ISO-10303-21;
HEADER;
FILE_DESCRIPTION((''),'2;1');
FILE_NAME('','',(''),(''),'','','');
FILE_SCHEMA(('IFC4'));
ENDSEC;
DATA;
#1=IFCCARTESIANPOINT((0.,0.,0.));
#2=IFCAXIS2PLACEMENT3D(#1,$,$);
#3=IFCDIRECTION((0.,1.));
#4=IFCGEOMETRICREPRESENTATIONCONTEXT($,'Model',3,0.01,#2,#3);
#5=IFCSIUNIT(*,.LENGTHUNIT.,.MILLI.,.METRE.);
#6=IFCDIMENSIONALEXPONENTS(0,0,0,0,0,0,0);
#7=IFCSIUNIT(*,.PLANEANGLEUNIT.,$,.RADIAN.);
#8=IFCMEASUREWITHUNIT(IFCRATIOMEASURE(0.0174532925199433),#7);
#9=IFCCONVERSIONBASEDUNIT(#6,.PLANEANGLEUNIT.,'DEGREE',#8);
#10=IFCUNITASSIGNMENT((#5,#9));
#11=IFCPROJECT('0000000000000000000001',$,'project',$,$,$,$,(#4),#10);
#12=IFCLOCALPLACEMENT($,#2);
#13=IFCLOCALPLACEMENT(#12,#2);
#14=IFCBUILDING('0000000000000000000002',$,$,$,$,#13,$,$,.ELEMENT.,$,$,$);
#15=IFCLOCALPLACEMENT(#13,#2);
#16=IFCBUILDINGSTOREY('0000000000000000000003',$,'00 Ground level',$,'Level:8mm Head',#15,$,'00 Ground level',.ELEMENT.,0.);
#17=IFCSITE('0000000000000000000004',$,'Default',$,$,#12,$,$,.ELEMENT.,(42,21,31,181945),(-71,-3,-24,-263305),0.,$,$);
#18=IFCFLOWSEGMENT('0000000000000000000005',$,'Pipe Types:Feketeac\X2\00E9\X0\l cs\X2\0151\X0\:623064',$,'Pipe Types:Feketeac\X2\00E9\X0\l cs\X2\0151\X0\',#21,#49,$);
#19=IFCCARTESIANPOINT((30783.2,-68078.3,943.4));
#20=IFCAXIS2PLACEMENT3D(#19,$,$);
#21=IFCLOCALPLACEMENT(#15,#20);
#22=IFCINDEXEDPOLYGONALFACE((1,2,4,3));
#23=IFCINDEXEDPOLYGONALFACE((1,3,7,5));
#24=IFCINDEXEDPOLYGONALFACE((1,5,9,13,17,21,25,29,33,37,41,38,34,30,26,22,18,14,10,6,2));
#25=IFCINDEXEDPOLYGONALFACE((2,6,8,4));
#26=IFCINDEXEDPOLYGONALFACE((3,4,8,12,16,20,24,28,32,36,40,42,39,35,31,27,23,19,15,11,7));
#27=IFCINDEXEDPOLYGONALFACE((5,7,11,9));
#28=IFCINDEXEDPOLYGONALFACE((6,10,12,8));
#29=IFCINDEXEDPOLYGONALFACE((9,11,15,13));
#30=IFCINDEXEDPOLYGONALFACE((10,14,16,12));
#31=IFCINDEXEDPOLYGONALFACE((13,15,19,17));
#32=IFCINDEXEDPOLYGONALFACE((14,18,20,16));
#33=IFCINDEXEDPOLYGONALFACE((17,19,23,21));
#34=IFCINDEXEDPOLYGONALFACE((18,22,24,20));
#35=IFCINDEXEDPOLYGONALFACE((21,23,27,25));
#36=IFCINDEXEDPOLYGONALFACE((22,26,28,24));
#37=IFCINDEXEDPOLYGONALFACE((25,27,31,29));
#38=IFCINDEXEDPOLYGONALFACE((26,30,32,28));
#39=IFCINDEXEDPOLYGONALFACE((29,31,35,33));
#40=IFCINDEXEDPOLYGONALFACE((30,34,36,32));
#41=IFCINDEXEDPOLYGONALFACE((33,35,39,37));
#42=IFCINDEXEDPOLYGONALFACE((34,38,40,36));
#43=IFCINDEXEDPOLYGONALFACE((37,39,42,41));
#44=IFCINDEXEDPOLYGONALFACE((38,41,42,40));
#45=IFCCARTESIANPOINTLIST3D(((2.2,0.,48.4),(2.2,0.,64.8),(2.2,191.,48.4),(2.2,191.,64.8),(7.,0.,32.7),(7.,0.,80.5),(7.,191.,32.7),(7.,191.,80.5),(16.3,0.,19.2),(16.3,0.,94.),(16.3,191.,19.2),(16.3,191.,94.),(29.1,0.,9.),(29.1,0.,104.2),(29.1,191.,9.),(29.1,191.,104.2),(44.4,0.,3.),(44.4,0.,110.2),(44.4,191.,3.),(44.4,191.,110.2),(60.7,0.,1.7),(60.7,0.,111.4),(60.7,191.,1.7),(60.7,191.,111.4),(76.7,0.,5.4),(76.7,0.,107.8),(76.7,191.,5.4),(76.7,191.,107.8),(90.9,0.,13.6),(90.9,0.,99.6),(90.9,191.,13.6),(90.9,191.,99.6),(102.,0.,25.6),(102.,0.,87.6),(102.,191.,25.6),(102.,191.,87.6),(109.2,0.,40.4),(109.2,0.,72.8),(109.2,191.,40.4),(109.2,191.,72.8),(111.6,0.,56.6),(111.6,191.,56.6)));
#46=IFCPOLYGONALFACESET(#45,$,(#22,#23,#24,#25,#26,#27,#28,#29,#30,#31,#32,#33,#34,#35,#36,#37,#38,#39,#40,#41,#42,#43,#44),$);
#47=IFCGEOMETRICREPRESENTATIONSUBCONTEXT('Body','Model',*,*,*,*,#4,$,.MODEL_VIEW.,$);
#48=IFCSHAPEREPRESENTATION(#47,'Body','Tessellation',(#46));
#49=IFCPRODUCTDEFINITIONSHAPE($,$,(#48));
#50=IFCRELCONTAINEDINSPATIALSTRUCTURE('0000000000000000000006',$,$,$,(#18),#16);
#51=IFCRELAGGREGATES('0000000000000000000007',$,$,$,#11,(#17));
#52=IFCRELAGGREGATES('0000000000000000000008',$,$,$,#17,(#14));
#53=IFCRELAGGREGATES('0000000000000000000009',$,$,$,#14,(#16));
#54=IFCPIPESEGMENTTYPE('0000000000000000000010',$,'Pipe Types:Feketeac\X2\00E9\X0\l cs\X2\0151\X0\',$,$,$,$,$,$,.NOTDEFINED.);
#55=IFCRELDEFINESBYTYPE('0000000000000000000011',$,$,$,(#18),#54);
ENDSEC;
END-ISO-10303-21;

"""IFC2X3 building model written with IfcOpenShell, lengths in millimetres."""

from ifc_helpers import new_model, entity, si_unit, converted_unit, direction, frame, origin, origin_2d_with_axis, place, context, subcontext, project, spatial, circle, extrude, type_object, element, save


model = new_model("IFC2X3")

# Units and contexts
model_context = context("Model", 3, precision=0.01, world=origin(), true_north=direction((0.0, 1.0)))
body_context = subcontext(model_context, "Body", "Model", "MODEL_VIEW")
ifc_project = project(units=[si_unit("LENGTHUNIT", "METRE", prefix="MILLI"), converted_unit("PLANEANGLEUNIT", "DEGREE", entity("IfcRatioMeasure", 0.0174532925199433), si_unit("PLANEANGLEUNIT", "RADIAN"), dimensions=[0, 0, 0, 0, 0, 0, 0])], contexts=[model_context])

# Site, building, storey
site_placement = place(None, origin())
site = spatial("IfcSite", under=ifc_project, at=site_placement, Name="Default", CompositionType="ELEMENT", RefLatitude=(42, 21, 31, 181945), RefLongitude=(-71, -3, -24, -263305), RefElevation=0.0)
building_placement = place(site_placement, origin())
building = spatial("IfcBuilding", under=site, at=building_placement, CompositionType="ELEMENT")
storey_placement = place(building_placement, origin())
storey = spatial("IfcBuildingStorey", under=building, at=storey_placement, Name="00 Ground level", ObjectType="Level:8mm Head", LongName="00 Ground level", CompositionType="ELEMENT", Elevation=0.0)

# Flow segment
pipe_segment_type = type_object("IfcPipeSegmentType", Name="Pipe Types:Feketeacél cső", PredefinedType="NOTDEFINED")
flow_segment_placement = place(storey_placement, frame((30783.2, -68078.3, 943.4)))
element("IfcFlowSegment", 1, at=flow_segment_placement, inside=storey, type_object=pipe_segment_type, Name="Pipe Types:Feketeacél cső:623064", ObjectType="Pipe Types:Feketeacél cső", context=body_context, shape_type="SweptSolid", body=[
    extrude(circle(Radius=55.0, at=origin_2d_with_axis()), frame((56.6, 0.0, 56.6), z_axis=(0.0, 1.0, 0.0), x_axis=(1.0, 0.0, 0.0)), (0.0, 0.0, 1.0), 191.0),
])

save(model, "model.ifc")
